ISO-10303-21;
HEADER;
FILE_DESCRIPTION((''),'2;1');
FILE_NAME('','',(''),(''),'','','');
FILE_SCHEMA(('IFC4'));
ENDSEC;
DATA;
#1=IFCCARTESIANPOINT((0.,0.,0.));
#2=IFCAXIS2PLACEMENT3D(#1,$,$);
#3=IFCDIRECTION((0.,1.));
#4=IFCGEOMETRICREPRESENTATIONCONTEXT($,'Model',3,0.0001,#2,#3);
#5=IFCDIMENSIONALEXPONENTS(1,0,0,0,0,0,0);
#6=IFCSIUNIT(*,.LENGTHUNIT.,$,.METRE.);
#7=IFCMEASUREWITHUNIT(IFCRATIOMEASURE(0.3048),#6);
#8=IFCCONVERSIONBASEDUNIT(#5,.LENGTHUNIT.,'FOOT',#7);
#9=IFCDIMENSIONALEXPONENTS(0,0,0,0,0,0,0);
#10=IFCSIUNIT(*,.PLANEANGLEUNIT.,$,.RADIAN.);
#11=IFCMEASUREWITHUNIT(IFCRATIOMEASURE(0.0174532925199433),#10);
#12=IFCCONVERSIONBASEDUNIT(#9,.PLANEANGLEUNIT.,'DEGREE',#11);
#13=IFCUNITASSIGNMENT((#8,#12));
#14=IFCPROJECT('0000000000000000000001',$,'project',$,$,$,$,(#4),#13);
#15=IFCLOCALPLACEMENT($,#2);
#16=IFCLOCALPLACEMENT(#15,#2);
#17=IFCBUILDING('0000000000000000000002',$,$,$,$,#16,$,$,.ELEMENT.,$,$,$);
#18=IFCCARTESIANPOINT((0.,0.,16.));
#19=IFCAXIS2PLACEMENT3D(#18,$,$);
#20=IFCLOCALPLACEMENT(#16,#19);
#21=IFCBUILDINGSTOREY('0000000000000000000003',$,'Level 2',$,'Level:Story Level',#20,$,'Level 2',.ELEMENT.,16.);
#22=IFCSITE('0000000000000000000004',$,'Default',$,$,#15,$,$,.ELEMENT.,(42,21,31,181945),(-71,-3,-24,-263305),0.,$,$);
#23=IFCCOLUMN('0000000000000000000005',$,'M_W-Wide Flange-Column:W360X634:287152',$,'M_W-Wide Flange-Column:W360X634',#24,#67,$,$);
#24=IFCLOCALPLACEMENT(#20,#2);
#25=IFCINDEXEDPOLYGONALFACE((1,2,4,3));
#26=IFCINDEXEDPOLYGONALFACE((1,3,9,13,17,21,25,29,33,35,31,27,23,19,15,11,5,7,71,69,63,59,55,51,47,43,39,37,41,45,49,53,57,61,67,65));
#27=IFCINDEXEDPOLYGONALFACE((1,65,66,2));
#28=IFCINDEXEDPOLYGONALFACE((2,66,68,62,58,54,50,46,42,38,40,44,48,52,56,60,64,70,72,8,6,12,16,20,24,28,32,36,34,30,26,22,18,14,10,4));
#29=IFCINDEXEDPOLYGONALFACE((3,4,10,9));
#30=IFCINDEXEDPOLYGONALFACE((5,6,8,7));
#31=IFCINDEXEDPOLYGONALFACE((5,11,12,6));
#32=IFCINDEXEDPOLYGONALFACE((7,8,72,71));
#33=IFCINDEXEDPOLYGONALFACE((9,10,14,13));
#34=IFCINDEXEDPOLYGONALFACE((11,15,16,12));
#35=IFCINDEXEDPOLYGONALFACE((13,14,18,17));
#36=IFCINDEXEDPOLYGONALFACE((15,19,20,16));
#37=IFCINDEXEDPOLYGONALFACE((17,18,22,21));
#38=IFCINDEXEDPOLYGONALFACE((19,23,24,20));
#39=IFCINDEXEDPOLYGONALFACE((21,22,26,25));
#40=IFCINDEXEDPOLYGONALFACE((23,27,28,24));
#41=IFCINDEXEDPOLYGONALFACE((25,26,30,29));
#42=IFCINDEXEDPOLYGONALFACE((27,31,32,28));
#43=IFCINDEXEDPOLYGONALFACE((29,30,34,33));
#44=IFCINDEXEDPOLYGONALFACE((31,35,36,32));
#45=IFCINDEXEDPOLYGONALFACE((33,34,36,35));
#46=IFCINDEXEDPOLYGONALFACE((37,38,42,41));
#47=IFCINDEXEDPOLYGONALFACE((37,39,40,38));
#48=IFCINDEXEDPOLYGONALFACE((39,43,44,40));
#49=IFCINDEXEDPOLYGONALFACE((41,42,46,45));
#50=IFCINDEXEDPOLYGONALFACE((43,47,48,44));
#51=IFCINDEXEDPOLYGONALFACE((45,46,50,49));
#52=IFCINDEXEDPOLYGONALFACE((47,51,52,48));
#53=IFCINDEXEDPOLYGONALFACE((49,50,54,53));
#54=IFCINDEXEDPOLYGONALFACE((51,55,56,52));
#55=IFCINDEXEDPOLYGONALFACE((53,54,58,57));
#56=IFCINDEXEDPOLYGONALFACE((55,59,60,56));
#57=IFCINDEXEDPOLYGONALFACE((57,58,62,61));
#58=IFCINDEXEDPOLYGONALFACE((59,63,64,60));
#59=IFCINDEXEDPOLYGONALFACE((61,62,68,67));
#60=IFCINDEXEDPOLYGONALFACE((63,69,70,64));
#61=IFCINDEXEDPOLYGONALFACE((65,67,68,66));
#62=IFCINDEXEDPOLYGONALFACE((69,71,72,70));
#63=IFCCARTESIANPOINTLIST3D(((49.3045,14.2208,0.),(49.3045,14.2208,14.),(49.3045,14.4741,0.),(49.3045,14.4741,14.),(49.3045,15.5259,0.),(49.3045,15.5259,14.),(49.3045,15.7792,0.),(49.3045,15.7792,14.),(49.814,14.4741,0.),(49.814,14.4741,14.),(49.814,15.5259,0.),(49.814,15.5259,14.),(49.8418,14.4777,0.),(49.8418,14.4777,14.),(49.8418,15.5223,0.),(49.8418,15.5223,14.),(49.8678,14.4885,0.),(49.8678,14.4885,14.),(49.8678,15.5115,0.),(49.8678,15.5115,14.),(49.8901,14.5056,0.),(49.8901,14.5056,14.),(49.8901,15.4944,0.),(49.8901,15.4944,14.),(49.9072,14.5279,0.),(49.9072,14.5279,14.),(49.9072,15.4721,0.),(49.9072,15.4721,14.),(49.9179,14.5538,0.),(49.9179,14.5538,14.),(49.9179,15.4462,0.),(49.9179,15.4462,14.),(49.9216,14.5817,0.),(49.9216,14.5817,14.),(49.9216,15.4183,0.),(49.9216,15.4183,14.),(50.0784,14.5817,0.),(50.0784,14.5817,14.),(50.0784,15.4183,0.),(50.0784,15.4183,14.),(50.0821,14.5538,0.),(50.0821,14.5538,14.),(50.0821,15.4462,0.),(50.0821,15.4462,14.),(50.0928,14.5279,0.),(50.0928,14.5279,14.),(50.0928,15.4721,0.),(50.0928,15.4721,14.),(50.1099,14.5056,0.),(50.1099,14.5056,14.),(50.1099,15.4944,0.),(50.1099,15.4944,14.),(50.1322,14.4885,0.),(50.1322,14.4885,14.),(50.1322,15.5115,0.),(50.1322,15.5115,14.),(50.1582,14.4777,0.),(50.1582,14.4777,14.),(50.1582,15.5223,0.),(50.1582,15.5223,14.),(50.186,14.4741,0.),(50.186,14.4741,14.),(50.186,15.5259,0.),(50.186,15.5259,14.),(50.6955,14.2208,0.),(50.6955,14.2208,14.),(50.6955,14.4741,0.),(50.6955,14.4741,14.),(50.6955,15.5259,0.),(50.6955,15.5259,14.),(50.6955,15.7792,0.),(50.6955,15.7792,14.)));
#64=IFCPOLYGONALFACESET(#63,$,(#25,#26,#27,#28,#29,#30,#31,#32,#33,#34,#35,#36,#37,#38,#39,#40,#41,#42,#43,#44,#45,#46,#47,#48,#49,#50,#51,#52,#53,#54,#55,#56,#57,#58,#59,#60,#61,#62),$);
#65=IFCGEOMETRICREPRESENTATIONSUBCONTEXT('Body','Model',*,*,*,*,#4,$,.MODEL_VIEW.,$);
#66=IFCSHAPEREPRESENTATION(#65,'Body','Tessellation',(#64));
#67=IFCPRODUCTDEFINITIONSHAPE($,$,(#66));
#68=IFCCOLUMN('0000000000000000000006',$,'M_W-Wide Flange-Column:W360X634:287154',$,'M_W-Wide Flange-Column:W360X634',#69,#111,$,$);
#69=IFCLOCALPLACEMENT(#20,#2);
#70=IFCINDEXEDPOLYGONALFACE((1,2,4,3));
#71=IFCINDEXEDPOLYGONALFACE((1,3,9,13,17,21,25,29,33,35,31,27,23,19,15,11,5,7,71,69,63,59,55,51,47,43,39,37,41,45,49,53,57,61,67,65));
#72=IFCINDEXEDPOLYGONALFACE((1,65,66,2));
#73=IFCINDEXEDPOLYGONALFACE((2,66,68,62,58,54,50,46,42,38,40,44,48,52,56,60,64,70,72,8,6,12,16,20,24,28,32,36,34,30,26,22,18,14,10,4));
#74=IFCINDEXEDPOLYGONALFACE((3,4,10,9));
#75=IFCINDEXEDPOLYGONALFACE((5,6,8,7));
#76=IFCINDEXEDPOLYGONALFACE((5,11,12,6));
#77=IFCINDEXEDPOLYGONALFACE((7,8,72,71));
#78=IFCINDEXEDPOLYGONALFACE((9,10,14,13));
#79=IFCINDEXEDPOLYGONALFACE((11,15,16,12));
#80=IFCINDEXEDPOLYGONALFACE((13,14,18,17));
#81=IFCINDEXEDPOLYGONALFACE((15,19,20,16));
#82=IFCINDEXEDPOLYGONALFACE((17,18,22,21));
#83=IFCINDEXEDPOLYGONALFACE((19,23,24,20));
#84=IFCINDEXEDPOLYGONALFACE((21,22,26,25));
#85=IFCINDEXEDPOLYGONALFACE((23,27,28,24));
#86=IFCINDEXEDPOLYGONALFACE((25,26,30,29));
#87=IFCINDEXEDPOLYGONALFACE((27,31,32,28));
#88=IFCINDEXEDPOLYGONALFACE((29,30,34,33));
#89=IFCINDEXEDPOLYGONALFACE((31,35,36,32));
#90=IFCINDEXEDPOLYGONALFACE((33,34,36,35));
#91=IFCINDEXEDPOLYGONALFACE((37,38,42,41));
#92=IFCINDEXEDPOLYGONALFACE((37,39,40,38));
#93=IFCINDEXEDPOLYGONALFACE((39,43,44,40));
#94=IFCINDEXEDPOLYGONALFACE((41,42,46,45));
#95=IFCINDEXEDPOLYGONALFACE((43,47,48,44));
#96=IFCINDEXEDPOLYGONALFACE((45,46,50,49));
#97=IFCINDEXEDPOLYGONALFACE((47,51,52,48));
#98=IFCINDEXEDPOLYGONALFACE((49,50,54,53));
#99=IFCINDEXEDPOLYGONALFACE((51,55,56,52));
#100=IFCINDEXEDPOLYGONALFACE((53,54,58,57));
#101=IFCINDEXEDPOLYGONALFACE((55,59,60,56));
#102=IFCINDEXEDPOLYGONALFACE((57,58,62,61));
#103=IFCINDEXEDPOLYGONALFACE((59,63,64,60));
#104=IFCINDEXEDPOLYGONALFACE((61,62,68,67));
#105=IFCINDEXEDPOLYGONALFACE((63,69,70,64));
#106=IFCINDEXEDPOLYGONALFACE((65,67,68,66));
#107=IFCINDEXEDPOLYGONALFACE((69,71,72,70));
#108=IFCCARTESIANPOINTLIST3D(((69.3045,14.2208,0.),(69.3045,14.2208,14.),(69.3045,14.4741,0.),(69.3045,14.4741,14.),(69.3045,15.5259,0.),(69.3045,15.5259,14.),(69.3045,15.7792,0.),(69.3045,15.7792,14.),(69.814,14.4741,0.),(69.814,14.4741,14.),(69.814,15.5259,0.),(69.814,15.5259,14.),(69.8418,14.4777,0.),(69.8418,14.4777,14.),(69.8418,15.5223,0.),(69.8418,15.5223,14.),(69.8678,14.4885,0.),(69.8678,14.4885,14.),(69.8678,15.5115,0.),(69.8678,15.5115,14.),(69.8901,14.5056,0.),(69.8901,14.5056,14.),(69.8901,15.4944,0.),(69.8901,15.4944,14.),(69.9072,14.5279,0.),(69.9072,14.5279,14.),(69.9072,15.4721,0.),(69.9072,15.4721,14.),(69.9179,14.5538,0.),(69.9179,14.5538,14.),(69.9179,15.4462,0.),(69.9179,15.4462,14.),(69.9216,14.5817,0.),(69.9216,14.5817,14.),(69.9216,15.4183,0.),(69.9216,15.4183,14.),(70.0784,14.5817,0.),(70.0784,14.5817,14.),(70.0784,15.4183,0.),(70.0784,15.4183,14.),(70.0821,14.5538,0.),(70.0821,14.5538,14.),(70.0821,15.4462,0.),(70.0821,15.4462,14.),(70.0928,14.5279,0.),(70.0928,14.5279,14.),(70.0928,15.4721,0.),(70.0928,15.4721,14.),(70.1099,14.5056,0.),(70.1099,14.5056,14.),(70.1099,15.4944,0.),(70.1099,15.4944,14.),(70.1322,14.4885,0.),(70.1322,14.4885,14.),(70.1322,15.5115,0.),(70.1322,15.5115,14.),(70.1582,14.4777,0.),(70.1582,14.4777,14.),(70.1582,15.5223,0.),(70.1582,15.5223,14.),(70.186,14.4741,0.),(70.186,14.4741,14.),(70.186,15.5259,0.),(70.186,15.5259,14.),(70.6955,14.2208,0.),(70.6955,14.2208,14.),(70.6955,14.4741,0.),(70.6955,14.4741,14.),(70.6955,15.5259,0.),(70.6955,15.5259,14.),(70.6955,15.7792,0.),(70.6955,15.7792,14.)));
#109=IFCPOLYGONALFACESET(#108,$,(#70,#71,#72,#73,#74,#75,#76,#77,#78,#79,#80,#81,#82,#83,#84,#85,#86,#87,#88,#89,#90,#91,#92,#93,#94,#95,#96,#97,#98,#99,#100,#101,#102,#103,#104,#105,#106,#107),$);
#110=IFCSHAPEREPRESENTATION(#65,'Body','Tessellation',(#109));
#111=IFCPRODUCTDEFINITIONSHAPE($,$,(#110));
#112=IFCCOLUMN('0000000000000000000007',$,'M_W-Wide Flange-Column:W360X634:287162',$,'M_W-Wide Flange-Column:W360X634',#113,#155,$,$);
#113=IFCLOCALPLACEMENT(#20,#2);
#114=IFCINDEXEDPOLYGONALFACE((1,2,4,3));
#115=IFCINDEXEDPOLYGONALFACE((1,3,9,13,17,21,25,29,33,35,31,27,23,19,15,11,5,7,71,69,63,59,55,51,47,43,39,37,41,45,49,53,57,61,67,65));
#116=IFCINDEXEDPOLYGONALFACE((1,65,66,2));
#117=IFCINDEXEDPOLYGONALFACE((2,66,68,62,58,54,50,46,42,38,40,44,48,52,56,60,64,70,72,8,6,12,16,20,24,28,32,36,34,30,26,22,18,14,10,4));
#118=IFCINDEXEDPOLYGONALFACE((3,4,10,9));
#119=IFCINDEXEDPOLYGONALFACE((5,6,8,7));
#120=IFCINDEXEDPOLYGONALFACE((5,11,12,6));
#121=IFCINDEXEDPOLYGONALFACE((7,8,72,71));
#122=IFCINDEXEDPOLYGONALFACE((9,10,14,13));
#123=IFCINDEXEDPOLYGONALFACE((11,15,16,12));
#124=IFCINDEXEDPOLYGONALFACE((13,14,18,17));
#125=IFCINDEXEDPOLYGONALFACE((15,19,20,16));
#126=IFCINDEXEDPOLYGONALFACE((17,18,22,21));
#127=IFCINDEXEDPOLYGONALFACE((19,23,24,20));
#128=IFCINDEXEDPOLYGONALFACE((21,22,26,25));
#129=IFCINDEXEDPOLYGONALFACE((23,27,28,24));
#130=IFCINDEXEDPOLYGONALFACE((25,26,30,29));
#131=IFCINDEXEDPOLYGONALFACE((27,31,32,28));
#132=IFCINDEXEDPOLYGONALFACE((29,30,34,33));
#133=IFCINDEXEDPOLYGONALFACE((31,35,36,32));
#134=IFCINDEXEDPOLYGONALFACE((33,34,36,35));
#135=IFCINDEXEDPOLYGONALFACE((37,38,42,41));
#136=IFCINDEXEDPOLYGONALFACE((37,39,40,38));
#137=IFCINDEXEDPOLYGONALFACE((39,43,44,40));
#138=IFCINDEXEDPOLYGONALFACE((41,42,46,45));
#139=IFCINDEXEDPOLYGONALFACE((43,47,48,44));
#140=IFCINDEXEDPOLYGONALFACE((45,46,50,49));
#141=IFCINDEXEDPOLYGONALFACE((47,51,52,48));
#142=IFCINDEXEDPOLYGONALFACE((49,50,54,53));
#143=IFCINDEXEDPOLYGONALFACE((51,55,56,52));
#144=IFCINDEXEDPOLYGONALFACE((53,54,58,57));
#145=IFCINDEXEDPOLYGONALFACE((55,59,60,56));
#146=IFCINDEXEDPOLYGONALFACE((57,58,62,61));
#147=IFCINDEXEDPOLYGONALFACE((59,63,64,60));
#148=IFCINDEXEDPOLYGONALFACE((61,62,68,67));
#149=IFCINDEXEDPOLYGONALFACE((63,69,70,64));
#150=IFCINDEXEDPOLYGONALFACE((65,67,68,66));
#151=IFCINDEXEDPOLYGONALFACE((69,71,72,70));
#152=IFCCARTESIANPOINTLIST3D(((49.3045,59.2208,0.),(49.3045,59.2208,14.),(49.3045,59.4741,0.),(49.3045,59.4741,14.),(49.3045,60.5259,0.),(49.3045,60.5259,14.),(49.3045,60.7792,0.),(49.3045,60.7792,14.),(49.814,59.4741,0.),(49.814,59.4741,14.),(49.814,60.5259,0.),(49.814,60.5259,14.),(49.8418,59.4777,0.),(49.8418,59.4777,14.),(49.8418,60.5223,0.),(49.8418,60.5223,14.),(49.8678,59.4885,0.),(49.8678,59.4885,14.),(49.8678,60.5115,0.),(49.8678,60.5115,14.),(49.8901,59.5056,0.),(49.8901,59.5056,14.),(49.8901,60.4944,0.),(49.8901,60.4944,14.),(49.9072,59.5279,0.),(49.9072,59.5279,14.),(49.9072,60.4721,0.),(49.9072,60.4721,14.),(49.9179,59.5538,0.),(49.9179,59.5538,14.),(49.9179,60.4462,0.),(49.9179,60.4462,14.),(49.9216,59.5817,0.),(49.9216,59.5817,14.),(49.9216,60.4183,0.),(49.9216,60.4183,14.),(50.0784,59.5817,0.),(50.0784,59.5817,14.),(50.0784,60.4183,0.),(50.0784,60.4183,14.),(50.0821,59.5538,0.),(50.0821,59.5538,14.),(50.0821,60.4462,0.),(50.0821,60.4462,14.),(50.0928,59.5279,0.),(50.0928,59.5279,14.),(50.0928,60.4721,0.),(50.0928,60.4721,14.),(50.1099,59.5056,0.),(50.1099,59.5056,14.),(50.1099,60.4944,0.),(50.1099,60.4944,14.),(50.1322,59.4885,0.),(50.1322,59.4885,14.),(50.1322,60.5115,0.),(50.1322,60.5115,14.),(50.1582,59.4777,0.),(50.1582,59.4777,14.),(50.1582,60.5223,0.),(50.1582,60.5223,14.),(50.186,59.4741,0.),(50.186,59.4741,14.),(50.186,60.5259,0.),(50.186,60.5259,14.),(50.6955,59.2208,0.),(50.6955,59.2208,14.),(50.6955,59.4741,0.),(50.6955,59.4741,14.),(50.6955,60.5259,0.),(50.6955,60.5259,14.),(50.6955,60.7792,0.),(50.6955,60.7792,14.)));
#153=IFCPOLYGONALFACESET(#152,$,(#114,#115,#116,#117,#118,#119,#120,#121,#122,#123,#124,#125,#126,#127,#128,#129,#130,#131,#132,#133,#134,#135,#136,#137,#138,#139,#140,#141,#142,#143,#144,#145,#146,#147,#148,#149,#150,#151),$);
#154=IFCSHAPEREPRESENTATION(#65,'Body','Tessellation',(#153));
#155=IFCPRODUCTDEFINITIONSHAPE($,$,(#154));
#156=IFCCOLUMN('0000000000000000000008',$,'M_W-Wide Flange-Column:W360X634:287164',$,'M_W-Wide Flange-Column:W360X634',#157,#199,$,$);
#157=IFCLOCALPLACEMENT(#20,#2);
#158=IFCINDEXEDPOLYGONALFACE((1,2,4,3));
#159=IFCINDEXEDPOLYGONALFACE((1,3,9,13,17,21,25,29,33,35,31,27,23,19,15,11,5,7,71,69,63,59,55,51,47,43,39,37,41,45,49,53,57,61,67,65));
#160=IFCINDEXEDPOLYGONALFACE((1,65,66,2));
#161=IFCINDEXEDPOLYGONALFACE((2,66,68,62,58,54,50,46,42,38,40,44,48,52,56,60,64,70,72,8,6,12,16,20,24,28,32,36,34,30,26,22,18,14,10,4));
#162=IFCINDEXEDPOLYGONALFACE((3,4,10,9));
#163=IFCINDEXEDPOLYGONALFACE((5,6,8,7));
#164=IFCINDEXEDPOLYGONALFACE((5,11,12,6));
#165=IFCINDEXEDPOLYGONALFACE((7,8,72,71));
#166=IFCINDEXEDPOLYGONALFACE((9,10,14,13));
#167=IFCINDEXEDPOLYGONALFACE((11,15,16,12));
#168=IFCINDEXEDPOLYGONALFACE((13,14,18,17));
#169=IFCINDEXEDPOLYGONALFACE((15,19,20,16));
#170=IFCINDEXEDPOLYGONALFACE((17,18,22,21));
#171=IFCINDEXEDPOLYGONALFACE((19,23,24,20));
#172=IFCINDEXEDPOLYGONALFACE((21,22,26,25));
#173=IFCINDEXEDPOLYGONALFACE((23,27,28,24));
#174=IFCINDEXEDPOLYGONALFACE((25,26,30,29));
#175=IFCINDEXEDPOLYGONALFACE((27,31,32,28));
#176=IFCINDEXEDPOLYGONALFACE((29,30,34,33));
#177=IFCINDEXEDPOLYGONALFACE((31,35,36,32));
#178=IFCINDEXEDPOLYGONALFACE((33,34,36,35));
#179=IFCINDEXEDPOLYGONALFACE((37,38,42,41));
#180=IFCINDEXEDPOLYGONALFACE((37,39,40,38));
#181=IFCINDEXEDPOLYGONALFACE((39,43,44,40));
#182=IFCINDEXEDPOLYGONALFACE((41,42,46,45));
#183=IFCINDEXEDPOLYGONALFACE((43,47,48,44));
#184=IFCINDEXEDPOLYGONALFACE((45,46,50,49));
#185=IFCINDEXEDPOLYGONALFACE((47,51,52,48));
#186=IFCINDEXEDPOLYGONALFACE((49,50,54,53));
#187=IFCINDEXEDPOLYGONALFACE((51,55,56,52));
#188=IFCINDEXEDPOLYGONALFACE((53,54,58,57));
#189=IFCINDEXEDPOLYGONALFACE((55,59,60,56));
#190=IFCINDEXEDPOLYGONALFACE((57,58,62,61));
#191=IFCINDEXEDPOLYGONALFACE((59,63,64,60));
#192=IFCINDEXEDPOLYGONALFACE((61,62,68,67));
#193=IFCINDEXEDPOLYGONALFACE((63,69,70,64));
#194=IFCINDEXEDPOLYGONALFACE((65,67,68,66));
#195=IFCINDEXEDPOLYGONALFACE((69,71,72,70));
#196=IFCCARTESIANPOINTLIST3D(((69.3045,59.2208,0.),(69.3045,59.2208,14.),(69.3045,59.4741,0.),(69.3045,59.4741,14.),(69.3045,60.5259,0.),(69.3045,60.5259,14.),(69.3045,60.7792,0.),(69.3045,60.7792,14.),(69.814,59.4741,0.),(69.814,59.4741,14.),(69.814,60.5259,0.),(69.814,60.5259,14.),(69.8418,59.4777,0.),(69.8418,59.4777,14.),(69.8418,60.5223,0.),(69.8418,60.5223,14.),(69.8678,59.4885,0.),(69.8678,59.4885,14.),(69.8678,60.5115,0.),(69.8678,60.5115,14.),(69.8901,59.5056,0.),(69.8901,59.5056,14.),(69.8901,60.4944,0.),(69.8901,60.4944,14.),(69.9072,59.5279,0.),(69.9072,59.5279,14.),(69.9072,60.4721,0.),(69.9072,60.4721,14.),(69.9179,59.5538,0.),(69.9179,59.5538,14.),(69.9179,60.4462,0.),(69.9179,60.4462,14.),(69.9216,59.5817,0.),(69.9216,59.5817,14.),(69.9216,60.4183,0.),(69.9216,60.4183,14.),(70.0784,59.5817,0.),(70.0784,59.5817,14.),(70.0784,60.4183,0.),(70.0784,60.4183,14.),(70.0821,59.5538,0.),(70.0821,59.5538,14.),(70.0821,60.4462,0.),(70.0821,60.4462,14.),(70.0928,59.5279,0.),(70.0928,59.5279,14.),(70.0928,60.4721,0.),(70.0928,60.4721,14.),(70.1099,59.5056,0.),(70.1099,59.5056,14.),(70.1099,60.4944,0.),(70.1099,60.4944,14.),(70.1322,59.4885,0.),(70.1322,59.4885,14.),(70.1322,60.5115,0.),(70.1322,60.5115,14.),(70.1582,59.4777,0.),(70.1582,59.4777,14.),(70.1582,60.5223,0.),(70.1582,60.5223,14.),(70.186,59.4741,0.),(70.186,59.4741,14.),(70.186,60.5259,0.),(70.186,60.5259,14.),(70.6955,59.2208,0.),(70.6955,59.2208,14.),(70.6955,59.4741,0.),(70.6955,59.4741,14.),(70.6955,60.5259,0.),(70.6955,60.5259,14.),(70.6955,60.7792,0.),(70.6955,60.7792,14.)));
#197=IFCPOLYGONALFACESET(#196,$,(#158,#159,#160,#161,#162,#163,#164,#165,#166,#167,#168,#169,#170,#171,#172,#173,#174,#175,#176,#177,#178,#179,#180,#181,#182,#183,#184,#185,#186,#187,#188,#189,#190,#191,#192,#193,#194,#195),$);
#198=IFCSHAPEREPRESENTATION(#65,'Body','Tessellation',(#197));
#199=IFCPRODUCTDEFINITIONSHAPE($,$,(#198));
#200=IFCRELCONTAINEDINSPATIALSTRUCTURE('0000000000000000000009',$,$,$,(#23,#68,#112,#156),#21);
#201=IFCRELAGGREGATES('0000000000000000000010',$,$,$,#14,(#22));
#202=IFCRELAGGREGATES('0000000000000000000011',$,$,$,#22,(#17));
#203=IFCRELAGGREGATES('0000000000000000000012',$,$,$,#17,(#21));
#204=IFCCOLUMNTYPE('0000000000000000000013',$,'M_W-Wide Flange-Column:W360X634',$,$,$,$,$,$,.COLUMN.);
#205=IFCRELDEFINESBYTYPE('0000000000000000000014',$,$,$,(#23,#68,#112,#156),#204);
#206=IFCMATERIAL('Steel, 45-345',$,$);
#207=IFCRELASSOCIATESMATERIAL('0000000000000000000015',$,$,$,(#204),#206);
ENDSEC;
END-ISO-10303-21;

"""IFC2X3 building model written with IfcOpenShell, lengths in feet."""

from ifc_helpers import new_model, entity, si_unit, converted_unit, direction, frame, frame_2d, origin, place, context, subcontext, project, spatial, polyline, circle_curve, parameter, trimmed, segment, composite_curve, outline, extrude, source, transform, mapped, material, type_object, type_shapes, element, save


model = new_model("IFC2X3")

# Units and contexts
model_context = context("Model", 3, precision=0.0001, world=origin(), true_north=direction((0.0, 1.0)))
body_context = subcontext(model_context, "Body", "Model", "MODEL_VIEW")
ifc_project = project(units=[converted_unit("LENGTHUNIT", "FOOT", entity("IfcRatioMeasure", 0.3048), si_unit("LENGTHUNIT", "METRE"), dimensions=[1, 0, 0, 0, 0, 0, 0]), converted_unit("PLANEANGLEUNIT", "DEGREE", entity("IfcRatioMeasure", 0.0174532925199433), si_unit("PLANEANGLEUNIT", "RADIAN"), dimensions=[0, 0, 0, 0, 0, 0, 0])], contexts=[model_context])

# Site, building, storey
site_placement = place(None, origin())
site = spatial("IfcSite", under=ifc_project, at=site_placement, Name="Default", CompositionType="ELEMENT", RefLatitude=(42, 21, 31, 181945), RefLongitude=(-71, -3, -24, -263305), RefElevation=0.0)
building_placement = place(site_placement, origin())
building = spatial("IfcBuilding", under=site, at=building_placement, CompositionType="ELEMENT")
storey_placement = place(building_placement, frame((0.0, 0.0, 16.0)))
storey = spatial("IfcBuildingStorey", under=building, at=storey_placement, Name="Level 2", ObjectType="Level:Story Level", LongName="Level 2", CompositionType="ELEMENT", Elevation=16.0)

# Columns
ifc_material = material(Name="Steel, 45-345")
column_type = type_object("IfcColumnType", Name="M_W-Wide Flange-Column:W360X634", PredefinedType="COLUMN", material=ifc_material)
shared_shape = source(origin(), body_context, "Body", "SweptSolid", [
    extrude(outline(composite_curve([segment(polyline([(0.5259, -0.6955), (0.7792, -0.6955)]), True, "CONTINUOUS"), segment(polyline([(0.7792, -0.6955), (0.7792, 0.6955)]), True, "CONTINUOUS"), segment(polyline([(0.7792, 0.6955), (0.5259, 0.6955)]), True, "CONTINUOUS"), segment(polyline([(0.5259, 0.6955), (0.5259, 0.186)]), True, "CONTINUOUS"), segment(trimmed(circle_curve(frame_2d((0.4183, 0.186), x_axis=(1.0, 0.0)), 0.1076), [parameter(270.0)], [parameter(0.0)], True, "PARAMETER"), False, "CONTINUOUS"), segment(polyline([(0.4183, 0.0784), (-0.4183, 0.0784)]), True, "CONTINUOUS"), segment(trimmed(circle_curve(frame_2d((-0.4183, 0.186), x_axis=(0.0, -1.0)), 0.1076), [parameter(270.0)], [parameter(0.0)], True, "PARAMETER"), False, "CONTINUOUS"), segment(polyline([(-0.5259, 0.186), (-0.5259, 0.6955)]), True, "CONTINUOUS"), segment(polyline([(-0.5259, 0.6955), (-0.7792, 0.6955)]), True, "CONTINUOUS"), segment(polyline([(-0.7792, 0.6955), (-0.7792, -0.6955)]), True, "CONTINUOUS"), segment(polyline([(-0.7792, -0.6955), (-0.5259, -0.6955)]), True, "CONTINUOUS"), segment(polyline([(-0.5259, -0.6955), (-0.5259, -0.186)]), True, "CONTINUOUS"), segment(trimmed(circle_curve(frame_2d((-0.4183, -0.186), x_axis=(-1.0, 0.0)), 0.1076), [parameter(270.0)], [parameter(0.0)], True, "PARAMETER"), False, "CONTINUOUS"), segment(polyline([(-0.4183, -0.0784), (0.4183, -0.0784)]), True, "CONTINUOUS"), segment(trimmed(circle_curve(frame_2d((0.4183, -0.186), x_axis=(0.0, 1.0)), 0.1076), [parameter(270.0)], [parameter(0.0)], True, "PARAMETER"), False, "CONTINUOUS"), segment(polyline([(0.5259, -0.186), (0.5259, -0.6955)]), True, "CONTINUOUS")], self_intersect=False)), frame((0.0, 0.0, 16.0), z_axis=(0.0, 0.0, 1.0), x_axis=(0.0, -1.0, 0.0)), (0.0, 0.0, 1.0), 14.0),
])
type_shapes(column_type, [shared_shape])
for number, where, name in (
    (1, (50.0, 15.0, -16.0), "M_W-Wide Flange-Column:W360X634:287152"),
    (2, (70.0, 15.0, -16.0), "M_W-Wide Flange-Column:W360X634:287154"),
    (3, (50.0, 60.0, -16.0), "M_W-Wide Flange-Column:W360X634:287162"),
    (4, (70.0, 60.0, -16.0), "M_W-Wide Flange-Column:W360X634:287164"),
):
    element("IfcColumn", number, at=place(storey_placement, frame(where)), inside=storey, type_object=column_type, Name=name, ObjectType="M_W-Wide Flange-Column:W360X634", context=body_context, shape_type="MappedRepresentation", body=[
        mapped(shared_shape, transform((0.0, 0.0, 0.0), scale=1.0)),
    ])

save(model, "model.ifc")
